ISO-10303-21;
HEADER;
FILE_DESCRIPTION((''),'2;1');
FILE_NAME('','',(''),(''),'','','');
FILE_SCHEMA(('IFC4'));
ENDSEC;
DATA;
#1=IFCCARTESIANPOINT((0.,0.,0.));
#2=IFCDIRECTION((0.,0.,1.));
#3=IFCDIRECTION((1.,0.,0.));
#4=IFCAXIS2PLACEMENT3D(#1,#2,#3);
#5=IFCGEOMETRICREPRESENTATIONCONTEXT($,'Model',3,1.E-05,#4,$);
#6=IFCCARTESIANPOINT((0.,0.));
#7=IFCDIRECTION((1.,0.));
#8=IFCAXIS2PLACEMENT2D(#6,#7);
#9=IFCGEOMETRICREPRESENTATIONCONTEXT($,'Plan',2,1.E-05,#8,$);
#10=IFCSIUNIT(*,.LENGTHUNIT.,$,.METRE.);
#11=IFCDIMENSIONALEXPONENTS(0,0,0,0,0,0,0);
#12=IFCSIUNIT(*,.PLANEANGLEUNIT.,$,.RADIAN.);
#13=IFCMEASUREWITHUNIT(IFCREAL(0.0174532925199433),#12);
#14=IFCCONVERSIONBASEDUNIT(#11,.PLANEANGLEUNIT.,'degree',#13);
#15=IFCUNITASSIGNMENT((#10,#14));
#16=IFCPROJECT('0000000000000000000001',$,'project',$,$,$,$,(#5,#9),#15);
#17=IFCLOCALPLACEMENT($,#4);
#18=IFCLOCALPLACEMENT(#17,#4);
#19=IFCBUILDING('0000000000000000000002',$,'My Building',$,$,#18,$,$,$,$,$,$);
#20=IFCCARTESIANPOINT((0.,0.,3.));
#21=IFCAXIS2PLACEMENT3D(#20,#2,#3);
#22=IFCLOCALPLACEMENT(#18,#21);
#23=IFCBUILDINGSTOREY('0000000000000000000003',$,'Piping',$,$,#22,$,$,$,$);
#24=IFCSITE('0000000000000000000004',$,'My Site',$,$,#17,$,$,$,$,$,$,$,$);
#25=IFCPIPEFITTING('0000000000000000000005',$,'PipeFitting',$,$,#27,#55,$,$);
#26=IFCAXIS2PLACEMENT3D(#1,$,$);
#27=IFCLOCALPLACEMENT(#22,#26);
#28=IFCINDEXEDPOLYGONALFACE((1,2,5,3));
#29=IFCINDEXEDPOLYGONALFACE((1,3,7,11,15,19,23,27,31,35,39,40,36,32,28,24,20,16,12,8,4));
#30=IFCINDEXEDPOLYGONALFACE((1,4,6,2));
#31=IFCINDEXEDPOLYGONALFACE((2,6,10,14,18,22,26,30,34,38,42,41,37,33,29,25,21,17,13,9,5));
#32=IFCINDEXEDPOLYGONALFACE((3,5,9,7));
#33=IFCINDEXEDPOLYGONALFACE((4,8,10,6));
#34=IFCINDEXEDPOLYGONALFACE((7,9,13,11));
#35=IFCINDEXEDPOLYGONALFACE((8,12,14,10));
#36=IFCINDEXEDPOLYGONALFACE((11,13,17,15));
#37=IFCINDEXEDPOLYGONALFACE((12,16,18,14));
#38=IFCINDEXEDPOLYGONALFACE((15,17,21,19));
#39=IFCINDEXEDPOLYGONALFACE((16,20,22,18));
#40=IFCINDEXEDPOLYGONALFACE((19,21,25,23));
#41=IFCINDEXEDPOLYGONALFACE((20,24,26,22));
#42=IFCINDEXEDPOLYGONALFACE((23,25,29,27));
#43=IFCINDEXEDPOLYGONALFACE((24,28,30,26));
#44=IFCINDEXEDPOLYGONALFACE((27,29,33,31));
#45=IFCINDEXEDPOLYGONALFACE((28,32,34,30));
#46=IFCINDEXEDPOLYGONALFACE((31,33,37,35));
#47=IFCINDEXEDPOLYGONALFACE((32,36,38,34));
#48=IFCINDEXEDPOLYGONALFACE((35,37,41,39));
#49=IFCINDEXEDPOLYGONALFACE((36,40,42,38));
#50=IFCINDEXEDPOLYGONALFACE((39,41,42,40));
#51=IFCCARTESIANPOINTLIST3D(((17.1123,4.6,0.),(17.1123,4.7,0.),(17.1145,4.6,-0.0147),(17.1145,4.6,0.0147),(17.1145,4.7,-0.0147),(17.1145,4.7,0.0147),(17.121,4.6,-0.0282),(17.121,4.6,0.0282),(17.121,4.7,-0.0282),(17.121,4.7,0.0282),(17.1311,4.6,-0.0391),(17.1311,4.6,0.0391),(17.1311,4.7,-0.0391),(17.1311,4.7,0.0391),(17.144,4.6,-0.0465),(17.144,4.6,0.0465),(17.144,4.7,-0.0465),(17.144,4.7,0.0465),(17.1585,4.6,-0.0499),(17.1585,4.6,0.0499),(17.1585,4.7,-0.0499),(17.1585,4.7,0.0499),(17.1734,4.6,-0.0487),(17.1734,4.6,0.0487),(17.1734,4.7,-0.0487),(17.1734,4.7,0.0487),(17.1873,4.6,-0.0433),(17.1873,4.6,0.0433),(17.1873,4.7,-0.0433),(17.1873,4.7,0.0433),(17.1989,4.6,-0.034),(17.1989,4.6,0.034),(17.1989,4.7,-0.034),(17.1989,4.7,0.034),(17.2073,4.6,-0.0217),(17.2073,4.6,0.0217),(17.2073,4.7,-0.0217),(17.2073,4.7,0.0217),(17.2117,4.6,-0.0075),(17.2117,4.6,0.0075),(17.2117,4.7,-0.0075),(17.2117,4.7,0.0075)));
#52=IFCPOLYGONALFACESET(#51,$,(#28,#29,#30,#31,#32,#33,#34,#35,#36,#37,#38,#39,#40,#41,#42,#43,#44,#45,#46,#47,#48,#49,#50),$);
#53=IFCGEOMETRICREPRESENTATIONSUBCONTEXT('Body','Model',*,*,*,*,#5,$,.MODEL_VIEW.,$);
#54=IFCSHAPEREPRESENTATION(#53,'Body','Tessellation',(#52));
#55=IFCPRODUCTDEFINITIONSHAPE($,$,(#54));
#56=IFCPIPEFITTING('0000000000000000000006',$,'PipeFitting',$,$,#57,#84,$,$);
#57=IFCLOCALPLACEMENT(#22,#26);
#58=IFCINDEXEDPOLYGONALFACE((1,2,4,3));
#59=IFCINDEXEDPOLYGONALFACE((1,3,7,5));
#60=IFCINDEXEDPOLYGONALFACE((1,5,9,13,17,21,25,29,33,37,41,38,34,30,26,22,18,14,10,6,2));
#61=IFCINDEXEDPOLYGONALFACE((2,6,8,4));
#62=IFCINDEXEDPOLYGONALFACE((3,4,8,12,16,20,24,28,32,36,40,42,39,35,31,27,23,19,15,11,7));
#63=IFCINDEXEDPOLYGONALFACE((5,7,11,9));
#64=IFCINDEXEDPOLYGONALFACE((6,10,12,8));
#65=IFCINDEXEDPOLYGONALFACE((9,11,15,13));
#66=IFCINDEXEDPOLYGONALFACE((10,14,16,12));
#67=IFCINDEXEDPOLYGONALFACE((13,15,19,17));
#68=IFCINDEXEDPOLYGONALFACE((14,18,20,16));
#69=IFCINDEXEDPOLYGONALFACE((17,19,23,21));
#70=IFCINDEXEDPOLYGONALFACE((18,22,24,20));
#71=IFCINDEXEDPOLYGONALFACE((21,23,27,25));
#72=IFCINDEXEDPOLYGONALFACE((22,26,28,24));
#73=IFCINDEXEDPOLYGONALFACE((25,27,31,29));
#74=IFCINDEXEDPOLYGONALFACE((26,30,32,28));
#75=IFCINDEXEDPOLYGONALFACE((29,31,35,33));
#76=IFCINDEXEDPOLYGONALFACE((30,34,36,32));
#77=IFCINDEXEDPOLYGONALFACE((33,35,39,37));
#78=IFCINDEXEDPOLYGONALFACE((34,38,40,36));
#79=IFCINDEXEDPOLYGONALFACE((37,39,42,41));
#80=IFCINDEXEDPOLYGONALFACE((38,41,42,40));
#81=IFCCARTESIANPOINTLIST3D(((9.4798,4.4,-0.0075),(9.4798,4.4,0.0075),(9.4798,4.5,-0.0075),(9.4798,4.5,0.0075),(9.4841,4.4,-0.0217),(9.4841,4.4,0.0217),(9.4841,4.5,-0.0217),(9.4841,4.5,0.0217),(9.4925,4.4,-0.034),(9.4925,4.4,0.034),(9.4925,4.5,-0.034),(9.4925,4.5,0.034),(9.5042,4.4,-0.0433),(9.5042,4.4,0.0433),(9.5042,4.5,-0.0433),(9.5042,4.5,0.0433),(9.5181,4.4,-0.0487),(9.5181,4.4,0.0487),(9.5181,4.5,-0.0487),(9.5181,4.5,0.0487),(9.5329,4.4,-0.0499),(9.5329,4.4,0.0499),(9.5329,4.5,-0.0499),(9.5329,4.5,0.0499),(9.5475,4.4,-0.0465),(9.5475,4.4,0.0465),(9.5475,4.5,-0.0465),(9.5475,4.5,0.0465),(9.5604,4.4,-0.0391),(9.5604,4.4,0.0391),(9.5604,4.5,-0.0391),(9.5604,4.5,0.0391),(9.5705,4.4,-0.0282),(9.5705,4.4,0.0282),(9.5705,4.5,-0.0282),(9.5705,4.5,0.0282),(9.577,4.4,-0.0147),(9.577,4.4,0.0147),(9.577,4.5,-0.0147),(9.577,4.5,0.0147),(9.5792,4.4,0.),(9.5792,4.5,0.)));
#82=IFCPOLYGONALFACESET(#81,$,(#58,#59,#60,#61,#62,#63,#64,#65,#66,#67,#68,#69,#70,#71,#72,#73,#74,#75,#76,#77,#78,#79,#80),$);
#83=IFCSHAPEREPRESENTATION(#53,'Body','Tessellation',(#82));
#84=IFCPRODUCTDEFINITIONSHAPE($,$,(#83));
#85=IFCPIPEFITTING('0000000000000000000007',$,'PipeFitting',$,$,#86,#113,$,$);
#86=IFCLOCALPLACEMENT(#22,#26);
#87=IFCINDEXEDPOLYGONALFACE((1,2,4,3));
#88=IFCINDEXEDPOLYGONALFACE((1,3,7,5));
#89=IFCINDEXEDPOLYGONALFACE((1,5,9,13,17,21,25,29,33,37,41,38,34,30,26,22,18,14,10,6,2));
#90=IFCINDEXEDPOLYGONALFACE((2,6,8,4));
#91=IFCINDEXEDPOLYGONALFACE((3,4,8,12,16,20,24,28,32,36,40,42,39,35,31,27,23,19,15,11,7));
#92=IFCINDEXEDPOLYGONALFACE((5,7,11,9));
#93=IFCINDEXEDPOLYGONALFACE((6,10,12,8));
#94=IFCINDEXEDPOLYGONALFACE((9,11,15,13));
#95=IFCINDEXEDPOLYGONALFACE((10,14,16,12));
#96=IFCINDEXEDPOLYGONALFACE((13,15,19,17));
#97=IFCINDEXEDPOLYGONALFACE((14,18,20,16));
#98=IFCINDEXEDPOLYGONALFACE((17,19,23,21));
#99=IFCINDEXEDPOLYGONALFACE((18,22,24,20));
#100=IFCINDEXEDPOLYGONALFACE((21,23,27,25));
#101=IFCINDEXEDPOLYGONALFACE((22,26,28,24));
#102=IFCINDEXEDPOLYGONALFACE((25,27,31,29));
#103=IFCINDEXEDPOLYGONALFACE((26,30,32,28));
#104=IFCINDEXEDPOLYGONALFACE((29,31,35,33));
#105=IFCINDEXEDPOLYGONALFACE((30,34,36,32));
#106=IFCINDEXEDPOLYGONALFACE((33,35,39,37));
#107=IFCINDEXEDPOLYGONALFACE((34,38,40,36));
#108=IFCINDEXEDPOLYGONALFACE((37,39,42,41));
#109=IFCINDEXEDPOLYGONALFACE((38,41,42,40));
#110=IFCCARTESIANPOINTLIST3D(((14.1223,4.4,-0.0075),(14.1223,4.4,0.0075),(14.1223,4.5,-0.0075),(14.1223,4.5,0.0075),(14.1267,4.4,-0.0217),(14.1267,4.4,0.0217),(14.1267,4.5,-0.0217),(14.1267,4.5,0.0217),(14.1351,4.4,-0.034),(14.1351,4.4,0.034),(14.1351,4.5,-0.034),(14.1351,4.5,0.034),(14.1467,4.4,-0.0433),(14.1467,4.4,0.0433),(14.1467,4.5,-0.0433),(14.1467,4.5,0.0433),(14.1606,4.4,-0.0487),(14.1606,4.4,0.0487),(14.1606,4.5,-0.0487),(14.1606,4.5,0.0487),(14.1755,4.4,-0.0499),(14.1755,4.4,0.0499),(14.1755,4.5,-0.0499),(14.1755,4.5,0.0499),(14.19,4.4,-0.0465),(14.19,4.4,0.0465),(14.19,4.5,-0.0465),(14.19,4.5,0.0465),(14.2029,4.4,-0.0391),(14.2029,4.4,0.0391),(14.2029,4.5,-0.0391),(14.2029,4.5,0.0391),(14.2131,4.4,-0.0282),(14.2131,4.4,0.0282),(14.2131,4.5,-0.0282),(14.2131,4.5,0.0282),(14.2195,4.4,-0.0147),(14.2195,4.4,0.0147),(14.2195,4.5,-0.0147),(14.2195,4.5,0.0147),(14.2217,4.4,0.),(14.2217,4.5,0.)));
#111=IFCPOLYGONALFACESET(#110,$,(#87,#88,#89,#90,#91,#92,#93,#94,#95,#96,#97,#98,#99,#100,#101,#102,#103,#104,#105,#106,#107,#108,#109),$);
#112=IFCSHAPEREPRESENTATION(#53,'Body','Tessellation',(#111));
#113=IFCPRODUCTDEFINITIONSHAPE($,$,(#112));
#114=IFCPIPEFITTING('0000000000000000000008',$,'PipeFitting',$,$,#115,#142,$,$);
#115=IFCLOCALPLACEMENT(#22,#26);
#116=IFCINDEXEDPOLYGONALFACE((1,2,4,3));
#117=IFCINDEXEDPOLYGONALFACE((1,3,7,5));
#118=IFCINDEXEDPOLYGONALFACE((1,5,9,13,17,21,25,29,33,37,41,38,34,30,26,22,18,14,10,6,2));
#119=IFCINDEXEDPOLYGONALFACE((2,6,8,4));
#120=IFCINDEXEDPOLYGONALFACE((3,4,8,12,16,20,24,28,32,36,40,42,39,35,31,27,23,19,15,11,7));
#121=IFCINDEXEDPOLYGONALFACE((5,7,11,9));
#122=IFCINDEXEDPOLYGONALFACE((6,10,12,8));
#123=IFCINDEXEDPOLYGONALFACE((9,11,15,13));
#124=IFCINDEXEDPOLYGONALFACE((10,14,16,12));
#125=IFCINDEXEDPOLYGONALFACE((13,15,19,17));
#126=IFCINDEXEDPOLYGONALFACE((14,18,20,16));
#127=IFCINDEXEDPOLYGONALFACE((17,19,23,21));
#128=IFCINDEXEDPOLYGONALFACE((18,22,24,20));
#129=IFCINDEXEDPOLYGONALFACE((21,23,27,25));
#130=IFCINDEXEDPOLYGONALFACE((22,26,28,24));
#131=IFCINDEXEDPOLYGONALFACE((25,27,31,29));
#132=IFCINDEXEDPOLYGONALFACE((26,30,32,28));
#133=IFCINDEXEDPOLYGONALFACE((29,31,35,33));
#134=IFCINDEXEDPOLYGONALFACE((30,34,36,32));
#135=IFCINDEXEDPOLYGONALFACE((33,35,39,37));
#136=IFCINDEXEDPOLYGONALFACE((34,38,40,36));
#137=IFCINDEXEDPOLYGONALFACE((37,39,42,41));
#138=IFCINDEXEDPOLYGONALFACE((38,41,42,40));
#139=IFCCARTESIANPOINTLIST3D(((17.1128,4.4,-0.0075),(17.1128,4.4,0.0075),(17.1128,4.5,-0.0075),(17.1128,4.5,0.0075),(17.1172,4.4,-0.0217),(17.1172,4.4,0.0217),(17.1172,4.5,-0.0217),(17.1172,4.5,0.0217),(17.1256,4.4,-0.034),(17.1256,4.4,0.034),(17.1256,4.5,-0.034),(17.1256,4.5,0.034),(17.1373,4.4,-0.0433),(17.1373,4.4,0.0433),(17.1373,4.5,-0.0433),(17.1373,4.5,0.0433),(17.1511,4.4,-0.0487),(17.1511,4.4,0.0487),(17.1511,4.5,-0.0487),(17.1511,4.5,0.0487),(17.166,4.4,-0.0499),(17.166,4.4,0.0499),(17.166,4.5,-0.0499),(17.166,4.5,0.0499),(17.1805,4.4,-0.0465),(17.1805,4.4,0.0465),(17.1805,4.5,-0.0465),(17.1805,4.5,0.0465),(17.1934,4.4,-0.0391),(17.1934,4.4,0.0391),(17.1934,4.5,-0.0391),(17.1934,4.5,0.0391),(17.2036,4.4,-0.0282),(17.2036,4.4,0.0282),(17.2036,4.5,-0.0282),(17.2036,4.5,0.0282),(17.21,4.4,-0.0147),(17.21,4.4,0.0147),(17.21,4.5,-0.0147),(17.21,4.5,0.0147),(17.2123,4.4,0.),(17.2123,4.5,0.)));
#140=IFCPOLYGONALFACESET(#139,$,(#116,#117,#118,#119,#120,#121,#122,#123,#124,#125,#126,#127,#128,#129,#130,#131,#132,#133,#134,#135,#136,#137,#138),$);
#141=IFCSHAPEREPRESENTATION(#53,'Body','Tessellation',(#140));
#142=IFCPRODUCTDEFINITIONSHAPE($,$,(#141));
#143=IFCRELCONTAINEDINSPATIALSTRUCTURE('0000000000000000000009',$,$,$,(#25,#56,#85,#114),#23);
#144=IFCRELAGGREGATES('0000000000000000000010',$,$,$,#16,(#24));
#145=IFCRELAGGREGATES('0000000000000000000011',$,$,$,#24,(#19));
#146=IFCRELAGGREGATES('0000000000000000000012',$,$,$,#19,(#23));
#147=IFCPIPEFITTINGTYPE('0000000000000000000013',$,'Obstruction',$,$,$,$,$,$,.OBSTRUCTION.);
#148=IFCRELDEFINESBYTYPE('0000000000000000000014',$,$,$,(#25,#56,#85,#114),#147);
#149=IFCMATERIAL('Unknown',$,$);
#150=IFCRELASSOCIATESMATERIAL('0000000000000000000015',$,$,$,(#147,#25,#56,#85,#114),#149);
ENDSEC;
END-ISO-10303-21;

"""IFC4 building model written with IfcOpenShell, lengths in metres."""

from ifc_helpers import new_model, entity, si_unit, converted_unit, frame, origin_with_axes, origin_2d_with_axis, place, context, subcontext, project, spatial, circle, extrude, material, material_profile, profile_set, profile_usage, type_object, element, save


model = new_model("IFC4")

# Units and contexts
model_context = context("Model", 3, precision=1e-05, world=origin_with_axes())
plan_context = context("Plan", 2, precision=1e-05, world=origin_2d_with_axis())
body_context = subcontext(model_context, "Body", "Model", "MODEL_VIEW")
ifc_project = project(units=[si_unit("LENGTHUNIT", "METRE"), converted_unit("PLANEANGLEUNIT", "degree", entity("IfcReal", 0.0174532925199433), si_unit("PLANEANGLEUNIT", "RADIAN"), dimensions=[0, 0, 0, 0, 0, 0, 0])], contexts=[model_context, plan_context])

# Site, building, storey
site_placement = place(None, origin_with_axes())
site = spatial("IfcSite", under=ifc_project, at=site_placement, Name="My Site")
building_placement = place(site_placement, origin_with_axes())
building = spatial("IfcBuilding", under=site, at=building_placement, Name="My Building")
storey_placement = place(building_placement, frame((0.0, 0.0, 3.0), z_axis=(0.0, 0.0, 1.0), x_axis=(1.0, 0.0, 0.0)))
storey = spatial("IfcBuildingStorey", under=building, at=storey_placement, Name="Piping")

# Shared definitions
ifc_material = material(Name="Unknown")

# Pipe fittings
ifc_material_profile_1 = material_profile(ifc_material, circle(Radius=0.05))
ifc_profile_set_1 = profile_set([ifc_material_profile_1])
pipe_fitting_type_1 = type_object("IfcPipeFittingType", Name="Obstruction", PredefinedType="OBSTRUCTION", material=ifc_profile_set_1)
ifc_profile_usage_1 = profile_usage(ifc_profile_set_1, cardinal=5)
pipe_fitting_1_placement = place(storey_placement, frame((17.1623, 4.6, 0.0), z_axis=(0.0, 1.0, 0.0), x_axis=(-1.0, 0.0, 0.0)))
element("IfcPipeFitting", 1, at=pipe_fitting_1_placement, inside=storey, type_object=pipe_fitting_type_1, material=ifc_profile_usage_1, Name="PipeFitting", context=body_context, shape_type="SweptSolid", body=[
    extrude(circle(Radius=0.05), origin_with_axes(), (0.0, 0.0, 1.0), 0.1),
])
ifc_profile_usage_2 = profile_usage(ifc_profile_set_1, cardinal=5)
pipe_fitting_2_placement = place(storey_placement, frame((9.5292, 4.5, 0.0), z_axis=(0.0, -1.0, 0.0), x_axis=(1.0, 0.0, 0.0)))
element("IfcPipeFitting", 2, at=pipe_fitting_2_placement, inside=storey, type_object=pipe_fitting_type_1, material=ifc_profile_usage_2, Name="PipeFitting", context=body_context, shape_type="SweptSolid", body=[
    extrude(circle(Radius=0.05), origin_with_axes(), (0.0, 0.0, 1.0), 0.1),
])
ifc_profile_usage_3 = profile_usage(ifc_profile_set_1, cardinal=5)
pipe_fitting_3_placement = place(storey_placement, frame((14.1717, 4.5, 0.0), z_axis=(0.0, -1.0, 0.0), x_axis=(1.0, 0.0, 0.0)))
element("IfcPipeFitting", 3, at=pipe_fitting_3_placement, inside=storey, type_object=pipe_fitting_type_1, material=ifc_profile_usage_3, Name="PipeFitting", context=body_context, shape_type="SweptSolid", body=[
    extrude(circle(Radius=0.05), origin_with_axes(), (0.0, 0.0, 1.0), 0.1),
])
ifc_profile_usage_4 = profile_usage(ifc_profile_set_1, cardinal=5)
pipe_fitting_4_placement = place(storey_placement, frame((17.1623, 4.5, 0.0), z_axis=(0.0, -1.0, 0.0), x_axis=(1.0, 0.0, 0.0)))
element("IfcPipeFitting", 4, at=pipe_fitting_4_placement, inside=storey, type_object=pipe_fitting_type_1, material=ifc_profile_usage_4, Name="PipeFitting", context=body_context, shape_type="SweptSolid", body=[
    extrude(circle(Radius=0.05), origin_with_axes(), (0.0, 0.0, 1.0), 0.1),
])

save(model, "model.ifc")
